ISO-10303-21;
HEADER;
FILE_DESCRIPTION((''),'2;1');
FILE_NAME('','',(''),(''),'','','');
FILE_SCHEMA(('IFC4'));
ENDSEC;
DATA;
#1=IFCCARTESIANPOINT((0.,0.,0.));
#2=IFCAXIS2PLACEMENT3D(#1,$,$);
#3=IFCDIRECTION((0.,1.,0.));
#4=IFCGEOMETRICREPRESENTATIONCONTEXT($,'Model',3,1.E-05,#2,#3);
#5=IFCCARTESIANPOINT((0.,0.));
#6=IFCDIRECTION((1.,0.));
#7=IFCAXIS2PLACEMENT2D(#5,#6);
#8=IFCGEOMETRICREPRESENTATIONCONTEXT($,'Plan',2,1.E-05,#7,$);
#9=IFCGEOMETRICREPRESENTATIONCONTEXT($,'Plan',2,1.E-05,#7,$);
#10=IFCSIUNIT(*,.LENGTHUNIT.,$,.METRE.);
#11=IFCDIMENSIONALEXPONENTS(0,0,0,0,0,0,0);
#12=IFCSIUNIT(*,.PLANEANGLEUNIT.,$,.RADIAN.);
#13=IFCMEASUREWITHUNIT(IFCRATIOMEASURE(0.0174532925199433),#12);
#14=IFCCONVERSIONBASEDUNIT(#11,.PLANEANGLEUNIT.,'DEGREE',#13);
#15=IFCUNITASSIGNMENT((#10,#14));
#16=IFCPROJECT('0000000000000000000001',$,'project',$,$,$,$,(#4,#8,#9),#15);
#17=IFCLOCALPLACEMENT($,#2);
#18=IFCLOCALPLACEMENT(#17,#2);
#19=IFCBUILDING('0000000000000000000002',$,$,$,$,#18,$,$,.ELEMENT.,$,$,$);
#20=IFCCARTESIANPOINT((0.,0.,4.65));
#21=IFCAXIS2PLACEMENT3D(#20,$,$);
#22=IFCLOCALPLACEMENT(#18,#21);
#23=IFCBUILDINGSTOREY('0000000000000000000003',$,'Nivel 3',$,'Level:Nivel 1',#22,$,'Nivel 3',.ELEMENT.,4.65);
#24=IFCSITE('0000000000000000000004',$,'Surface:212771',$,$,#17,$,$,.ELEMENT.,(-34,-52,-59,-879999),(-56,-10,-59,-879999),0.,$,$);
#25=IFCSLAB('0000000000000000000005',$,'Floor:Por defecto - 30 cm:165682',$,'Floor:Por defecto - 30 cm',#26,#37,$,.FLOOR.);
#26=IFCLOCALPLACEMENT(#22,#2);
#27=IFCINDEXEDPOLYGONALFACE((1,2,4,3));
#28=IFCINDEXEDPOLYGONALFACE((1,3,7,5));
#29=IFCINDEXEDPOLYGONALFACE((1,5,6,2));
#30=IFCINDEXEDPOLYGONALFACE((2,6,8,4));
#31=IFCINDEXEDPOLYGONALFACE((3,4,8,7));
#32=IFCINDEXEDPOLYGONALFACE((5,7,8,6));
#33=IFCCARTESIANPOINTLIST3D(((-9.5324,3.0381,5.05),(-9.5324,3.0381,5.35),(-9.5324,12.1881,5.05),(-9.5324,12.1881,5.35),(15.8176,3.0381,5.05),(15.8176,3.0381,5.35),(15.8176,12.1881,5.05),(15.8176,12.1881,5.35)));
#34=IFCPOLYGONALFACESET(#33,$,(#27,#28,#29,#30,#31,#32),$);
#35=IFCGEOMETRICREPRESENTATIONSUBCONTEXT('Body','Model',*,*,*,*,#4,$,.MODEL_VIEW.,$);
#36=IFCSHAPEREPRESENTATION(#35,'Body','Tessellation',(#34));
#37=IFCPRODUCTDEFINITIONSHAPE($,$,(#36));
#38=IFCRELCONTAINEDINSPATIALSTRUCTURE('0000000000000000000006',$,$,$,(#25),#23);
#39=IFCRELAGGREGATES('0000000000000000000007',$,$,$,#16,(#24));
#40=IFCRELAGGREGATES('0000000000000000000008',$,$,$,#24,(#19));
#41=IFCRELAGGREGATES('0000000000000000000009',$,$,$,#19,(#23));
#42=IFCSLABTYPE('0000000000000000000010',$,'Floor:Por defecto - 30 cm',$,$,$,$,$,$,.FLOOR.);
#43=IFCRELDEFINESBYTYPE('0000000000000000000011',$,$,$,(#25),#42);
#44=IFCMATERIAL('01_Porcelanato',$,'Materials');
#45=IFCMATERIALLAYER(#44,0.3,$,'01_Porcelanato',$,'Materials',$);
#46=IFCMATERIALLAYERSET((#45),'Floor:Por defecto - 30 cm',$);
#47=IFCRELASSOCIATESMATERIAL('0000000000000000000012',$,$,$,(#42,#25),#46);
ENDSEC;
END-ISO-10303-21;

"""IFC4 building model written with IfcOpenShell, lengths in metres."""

from ifc_helpers import new_model, entity, si_unit, converted_unit, direction, frame, origin, origin_2d_with_axis, place, context, subcontext, project, spatial, indexed_curve, outline, extrude, material, layer, layer_set, type_object, element, save


model = new_model("IFC4")

# Units and contexts
model_context = context("Model", 3, precision=1e-05, world=origin(), true_north=direction((0.0, 1.0, 0.0)))
plan_context_1 = context("Plan", 2, precision=1e-05, world=origin_2d_with_axis())
plan_context_2 = context("Plan", 2, precision=1e-05, world=origin_2d_with_axis())
body_context = subcontext(model_context, "Body", "Model", "MODEL_VIEW")
ifc_project = project(units=[si_unit("LENGTHUNIT", "METRE"), converted_unit("PLANEANGLEUNIT", "DEGREE", entity("IfcRatioMeasure", 0.0174532925199433), si_unit("PLANEANGLEUNIT", "RADIAN"), dimensions=[0, 0, 0, 0, 0, 0, 0])], contexts=[model_context, plan_context_1, plan_context_2])

# Site, building, storey
site_placement = place(None, origin())
site = spatial("IfcSite", under=ifc_project, at=site_placement, Name="Surface:212771", CompositionType="ELEMENT", RefLatitude=(-34, -52, -59, -879999), RefLongitude=(-56, -10, -59, -879999), RefElevation=0.0)
building_placement = place(site_placement, origin())
building = spatial("IfcBuilding", under=site, at=building_placement, CompositionType="ELEMENT")
storey_placement = place(building_placement, frame((0.0, 0.0, 4.65)))
storey = spatial("IfcBuildingStorey", under=building, at=storey_placement, Name="Nivel 3", ObjectType="Level:Nivel 1", LongName="Nivel 3", CompositionType="ELEMENT", Elevation=4.65)

# Slab
ifc_material = material(Name="01_Porcelanato", Category="Materials")
ifc_layer = layer(ifc_material, 0.3, Name="01_Porcelanato", Category="Materials")
ifc_layer_set = layer_set([ifc_layer], Name="Floor:Por defecto - 30 cm")
slab_type = type_object("IfcSlabType", Name="Floor:Por defecto - 30 cm", PredefinedType="FLOOR", material=ifc_layer_set)
slab_placement = place(storey_placement, frame((0.0, 0.0, 5.35), z_axis=(0.0, 0.0, 1.0), x_axis=(1.0, 0.0, 0.0)))
element("IfcSlab", 1, at=slab_placement, inside=storey, type_object=slab_type, material=ifc_layer_set, Name="Floor:Por defecto - 30 cm:165682", ObjectType="Floor:Por defecto - 30 cm", PredefinedType="FLOOR", context=body_context, shape_type="SweptSolid", body=[
    extrude(outline(indexed_curve([(-4.575, -12.675), (4.575, -12.675), (4.575, 12.675), (-4.575, 12.675), (-4.575, -12.675)], self_intersect=False)), frame((3.1426, 7.6131, 0.0), z_axis=(0.0, 0.0, -1.0), x_axis=(0.0, 1.0, 0.0)), (0.0, 0.0, 1.0), 0.3),
])

save(model, "model.ifc")
